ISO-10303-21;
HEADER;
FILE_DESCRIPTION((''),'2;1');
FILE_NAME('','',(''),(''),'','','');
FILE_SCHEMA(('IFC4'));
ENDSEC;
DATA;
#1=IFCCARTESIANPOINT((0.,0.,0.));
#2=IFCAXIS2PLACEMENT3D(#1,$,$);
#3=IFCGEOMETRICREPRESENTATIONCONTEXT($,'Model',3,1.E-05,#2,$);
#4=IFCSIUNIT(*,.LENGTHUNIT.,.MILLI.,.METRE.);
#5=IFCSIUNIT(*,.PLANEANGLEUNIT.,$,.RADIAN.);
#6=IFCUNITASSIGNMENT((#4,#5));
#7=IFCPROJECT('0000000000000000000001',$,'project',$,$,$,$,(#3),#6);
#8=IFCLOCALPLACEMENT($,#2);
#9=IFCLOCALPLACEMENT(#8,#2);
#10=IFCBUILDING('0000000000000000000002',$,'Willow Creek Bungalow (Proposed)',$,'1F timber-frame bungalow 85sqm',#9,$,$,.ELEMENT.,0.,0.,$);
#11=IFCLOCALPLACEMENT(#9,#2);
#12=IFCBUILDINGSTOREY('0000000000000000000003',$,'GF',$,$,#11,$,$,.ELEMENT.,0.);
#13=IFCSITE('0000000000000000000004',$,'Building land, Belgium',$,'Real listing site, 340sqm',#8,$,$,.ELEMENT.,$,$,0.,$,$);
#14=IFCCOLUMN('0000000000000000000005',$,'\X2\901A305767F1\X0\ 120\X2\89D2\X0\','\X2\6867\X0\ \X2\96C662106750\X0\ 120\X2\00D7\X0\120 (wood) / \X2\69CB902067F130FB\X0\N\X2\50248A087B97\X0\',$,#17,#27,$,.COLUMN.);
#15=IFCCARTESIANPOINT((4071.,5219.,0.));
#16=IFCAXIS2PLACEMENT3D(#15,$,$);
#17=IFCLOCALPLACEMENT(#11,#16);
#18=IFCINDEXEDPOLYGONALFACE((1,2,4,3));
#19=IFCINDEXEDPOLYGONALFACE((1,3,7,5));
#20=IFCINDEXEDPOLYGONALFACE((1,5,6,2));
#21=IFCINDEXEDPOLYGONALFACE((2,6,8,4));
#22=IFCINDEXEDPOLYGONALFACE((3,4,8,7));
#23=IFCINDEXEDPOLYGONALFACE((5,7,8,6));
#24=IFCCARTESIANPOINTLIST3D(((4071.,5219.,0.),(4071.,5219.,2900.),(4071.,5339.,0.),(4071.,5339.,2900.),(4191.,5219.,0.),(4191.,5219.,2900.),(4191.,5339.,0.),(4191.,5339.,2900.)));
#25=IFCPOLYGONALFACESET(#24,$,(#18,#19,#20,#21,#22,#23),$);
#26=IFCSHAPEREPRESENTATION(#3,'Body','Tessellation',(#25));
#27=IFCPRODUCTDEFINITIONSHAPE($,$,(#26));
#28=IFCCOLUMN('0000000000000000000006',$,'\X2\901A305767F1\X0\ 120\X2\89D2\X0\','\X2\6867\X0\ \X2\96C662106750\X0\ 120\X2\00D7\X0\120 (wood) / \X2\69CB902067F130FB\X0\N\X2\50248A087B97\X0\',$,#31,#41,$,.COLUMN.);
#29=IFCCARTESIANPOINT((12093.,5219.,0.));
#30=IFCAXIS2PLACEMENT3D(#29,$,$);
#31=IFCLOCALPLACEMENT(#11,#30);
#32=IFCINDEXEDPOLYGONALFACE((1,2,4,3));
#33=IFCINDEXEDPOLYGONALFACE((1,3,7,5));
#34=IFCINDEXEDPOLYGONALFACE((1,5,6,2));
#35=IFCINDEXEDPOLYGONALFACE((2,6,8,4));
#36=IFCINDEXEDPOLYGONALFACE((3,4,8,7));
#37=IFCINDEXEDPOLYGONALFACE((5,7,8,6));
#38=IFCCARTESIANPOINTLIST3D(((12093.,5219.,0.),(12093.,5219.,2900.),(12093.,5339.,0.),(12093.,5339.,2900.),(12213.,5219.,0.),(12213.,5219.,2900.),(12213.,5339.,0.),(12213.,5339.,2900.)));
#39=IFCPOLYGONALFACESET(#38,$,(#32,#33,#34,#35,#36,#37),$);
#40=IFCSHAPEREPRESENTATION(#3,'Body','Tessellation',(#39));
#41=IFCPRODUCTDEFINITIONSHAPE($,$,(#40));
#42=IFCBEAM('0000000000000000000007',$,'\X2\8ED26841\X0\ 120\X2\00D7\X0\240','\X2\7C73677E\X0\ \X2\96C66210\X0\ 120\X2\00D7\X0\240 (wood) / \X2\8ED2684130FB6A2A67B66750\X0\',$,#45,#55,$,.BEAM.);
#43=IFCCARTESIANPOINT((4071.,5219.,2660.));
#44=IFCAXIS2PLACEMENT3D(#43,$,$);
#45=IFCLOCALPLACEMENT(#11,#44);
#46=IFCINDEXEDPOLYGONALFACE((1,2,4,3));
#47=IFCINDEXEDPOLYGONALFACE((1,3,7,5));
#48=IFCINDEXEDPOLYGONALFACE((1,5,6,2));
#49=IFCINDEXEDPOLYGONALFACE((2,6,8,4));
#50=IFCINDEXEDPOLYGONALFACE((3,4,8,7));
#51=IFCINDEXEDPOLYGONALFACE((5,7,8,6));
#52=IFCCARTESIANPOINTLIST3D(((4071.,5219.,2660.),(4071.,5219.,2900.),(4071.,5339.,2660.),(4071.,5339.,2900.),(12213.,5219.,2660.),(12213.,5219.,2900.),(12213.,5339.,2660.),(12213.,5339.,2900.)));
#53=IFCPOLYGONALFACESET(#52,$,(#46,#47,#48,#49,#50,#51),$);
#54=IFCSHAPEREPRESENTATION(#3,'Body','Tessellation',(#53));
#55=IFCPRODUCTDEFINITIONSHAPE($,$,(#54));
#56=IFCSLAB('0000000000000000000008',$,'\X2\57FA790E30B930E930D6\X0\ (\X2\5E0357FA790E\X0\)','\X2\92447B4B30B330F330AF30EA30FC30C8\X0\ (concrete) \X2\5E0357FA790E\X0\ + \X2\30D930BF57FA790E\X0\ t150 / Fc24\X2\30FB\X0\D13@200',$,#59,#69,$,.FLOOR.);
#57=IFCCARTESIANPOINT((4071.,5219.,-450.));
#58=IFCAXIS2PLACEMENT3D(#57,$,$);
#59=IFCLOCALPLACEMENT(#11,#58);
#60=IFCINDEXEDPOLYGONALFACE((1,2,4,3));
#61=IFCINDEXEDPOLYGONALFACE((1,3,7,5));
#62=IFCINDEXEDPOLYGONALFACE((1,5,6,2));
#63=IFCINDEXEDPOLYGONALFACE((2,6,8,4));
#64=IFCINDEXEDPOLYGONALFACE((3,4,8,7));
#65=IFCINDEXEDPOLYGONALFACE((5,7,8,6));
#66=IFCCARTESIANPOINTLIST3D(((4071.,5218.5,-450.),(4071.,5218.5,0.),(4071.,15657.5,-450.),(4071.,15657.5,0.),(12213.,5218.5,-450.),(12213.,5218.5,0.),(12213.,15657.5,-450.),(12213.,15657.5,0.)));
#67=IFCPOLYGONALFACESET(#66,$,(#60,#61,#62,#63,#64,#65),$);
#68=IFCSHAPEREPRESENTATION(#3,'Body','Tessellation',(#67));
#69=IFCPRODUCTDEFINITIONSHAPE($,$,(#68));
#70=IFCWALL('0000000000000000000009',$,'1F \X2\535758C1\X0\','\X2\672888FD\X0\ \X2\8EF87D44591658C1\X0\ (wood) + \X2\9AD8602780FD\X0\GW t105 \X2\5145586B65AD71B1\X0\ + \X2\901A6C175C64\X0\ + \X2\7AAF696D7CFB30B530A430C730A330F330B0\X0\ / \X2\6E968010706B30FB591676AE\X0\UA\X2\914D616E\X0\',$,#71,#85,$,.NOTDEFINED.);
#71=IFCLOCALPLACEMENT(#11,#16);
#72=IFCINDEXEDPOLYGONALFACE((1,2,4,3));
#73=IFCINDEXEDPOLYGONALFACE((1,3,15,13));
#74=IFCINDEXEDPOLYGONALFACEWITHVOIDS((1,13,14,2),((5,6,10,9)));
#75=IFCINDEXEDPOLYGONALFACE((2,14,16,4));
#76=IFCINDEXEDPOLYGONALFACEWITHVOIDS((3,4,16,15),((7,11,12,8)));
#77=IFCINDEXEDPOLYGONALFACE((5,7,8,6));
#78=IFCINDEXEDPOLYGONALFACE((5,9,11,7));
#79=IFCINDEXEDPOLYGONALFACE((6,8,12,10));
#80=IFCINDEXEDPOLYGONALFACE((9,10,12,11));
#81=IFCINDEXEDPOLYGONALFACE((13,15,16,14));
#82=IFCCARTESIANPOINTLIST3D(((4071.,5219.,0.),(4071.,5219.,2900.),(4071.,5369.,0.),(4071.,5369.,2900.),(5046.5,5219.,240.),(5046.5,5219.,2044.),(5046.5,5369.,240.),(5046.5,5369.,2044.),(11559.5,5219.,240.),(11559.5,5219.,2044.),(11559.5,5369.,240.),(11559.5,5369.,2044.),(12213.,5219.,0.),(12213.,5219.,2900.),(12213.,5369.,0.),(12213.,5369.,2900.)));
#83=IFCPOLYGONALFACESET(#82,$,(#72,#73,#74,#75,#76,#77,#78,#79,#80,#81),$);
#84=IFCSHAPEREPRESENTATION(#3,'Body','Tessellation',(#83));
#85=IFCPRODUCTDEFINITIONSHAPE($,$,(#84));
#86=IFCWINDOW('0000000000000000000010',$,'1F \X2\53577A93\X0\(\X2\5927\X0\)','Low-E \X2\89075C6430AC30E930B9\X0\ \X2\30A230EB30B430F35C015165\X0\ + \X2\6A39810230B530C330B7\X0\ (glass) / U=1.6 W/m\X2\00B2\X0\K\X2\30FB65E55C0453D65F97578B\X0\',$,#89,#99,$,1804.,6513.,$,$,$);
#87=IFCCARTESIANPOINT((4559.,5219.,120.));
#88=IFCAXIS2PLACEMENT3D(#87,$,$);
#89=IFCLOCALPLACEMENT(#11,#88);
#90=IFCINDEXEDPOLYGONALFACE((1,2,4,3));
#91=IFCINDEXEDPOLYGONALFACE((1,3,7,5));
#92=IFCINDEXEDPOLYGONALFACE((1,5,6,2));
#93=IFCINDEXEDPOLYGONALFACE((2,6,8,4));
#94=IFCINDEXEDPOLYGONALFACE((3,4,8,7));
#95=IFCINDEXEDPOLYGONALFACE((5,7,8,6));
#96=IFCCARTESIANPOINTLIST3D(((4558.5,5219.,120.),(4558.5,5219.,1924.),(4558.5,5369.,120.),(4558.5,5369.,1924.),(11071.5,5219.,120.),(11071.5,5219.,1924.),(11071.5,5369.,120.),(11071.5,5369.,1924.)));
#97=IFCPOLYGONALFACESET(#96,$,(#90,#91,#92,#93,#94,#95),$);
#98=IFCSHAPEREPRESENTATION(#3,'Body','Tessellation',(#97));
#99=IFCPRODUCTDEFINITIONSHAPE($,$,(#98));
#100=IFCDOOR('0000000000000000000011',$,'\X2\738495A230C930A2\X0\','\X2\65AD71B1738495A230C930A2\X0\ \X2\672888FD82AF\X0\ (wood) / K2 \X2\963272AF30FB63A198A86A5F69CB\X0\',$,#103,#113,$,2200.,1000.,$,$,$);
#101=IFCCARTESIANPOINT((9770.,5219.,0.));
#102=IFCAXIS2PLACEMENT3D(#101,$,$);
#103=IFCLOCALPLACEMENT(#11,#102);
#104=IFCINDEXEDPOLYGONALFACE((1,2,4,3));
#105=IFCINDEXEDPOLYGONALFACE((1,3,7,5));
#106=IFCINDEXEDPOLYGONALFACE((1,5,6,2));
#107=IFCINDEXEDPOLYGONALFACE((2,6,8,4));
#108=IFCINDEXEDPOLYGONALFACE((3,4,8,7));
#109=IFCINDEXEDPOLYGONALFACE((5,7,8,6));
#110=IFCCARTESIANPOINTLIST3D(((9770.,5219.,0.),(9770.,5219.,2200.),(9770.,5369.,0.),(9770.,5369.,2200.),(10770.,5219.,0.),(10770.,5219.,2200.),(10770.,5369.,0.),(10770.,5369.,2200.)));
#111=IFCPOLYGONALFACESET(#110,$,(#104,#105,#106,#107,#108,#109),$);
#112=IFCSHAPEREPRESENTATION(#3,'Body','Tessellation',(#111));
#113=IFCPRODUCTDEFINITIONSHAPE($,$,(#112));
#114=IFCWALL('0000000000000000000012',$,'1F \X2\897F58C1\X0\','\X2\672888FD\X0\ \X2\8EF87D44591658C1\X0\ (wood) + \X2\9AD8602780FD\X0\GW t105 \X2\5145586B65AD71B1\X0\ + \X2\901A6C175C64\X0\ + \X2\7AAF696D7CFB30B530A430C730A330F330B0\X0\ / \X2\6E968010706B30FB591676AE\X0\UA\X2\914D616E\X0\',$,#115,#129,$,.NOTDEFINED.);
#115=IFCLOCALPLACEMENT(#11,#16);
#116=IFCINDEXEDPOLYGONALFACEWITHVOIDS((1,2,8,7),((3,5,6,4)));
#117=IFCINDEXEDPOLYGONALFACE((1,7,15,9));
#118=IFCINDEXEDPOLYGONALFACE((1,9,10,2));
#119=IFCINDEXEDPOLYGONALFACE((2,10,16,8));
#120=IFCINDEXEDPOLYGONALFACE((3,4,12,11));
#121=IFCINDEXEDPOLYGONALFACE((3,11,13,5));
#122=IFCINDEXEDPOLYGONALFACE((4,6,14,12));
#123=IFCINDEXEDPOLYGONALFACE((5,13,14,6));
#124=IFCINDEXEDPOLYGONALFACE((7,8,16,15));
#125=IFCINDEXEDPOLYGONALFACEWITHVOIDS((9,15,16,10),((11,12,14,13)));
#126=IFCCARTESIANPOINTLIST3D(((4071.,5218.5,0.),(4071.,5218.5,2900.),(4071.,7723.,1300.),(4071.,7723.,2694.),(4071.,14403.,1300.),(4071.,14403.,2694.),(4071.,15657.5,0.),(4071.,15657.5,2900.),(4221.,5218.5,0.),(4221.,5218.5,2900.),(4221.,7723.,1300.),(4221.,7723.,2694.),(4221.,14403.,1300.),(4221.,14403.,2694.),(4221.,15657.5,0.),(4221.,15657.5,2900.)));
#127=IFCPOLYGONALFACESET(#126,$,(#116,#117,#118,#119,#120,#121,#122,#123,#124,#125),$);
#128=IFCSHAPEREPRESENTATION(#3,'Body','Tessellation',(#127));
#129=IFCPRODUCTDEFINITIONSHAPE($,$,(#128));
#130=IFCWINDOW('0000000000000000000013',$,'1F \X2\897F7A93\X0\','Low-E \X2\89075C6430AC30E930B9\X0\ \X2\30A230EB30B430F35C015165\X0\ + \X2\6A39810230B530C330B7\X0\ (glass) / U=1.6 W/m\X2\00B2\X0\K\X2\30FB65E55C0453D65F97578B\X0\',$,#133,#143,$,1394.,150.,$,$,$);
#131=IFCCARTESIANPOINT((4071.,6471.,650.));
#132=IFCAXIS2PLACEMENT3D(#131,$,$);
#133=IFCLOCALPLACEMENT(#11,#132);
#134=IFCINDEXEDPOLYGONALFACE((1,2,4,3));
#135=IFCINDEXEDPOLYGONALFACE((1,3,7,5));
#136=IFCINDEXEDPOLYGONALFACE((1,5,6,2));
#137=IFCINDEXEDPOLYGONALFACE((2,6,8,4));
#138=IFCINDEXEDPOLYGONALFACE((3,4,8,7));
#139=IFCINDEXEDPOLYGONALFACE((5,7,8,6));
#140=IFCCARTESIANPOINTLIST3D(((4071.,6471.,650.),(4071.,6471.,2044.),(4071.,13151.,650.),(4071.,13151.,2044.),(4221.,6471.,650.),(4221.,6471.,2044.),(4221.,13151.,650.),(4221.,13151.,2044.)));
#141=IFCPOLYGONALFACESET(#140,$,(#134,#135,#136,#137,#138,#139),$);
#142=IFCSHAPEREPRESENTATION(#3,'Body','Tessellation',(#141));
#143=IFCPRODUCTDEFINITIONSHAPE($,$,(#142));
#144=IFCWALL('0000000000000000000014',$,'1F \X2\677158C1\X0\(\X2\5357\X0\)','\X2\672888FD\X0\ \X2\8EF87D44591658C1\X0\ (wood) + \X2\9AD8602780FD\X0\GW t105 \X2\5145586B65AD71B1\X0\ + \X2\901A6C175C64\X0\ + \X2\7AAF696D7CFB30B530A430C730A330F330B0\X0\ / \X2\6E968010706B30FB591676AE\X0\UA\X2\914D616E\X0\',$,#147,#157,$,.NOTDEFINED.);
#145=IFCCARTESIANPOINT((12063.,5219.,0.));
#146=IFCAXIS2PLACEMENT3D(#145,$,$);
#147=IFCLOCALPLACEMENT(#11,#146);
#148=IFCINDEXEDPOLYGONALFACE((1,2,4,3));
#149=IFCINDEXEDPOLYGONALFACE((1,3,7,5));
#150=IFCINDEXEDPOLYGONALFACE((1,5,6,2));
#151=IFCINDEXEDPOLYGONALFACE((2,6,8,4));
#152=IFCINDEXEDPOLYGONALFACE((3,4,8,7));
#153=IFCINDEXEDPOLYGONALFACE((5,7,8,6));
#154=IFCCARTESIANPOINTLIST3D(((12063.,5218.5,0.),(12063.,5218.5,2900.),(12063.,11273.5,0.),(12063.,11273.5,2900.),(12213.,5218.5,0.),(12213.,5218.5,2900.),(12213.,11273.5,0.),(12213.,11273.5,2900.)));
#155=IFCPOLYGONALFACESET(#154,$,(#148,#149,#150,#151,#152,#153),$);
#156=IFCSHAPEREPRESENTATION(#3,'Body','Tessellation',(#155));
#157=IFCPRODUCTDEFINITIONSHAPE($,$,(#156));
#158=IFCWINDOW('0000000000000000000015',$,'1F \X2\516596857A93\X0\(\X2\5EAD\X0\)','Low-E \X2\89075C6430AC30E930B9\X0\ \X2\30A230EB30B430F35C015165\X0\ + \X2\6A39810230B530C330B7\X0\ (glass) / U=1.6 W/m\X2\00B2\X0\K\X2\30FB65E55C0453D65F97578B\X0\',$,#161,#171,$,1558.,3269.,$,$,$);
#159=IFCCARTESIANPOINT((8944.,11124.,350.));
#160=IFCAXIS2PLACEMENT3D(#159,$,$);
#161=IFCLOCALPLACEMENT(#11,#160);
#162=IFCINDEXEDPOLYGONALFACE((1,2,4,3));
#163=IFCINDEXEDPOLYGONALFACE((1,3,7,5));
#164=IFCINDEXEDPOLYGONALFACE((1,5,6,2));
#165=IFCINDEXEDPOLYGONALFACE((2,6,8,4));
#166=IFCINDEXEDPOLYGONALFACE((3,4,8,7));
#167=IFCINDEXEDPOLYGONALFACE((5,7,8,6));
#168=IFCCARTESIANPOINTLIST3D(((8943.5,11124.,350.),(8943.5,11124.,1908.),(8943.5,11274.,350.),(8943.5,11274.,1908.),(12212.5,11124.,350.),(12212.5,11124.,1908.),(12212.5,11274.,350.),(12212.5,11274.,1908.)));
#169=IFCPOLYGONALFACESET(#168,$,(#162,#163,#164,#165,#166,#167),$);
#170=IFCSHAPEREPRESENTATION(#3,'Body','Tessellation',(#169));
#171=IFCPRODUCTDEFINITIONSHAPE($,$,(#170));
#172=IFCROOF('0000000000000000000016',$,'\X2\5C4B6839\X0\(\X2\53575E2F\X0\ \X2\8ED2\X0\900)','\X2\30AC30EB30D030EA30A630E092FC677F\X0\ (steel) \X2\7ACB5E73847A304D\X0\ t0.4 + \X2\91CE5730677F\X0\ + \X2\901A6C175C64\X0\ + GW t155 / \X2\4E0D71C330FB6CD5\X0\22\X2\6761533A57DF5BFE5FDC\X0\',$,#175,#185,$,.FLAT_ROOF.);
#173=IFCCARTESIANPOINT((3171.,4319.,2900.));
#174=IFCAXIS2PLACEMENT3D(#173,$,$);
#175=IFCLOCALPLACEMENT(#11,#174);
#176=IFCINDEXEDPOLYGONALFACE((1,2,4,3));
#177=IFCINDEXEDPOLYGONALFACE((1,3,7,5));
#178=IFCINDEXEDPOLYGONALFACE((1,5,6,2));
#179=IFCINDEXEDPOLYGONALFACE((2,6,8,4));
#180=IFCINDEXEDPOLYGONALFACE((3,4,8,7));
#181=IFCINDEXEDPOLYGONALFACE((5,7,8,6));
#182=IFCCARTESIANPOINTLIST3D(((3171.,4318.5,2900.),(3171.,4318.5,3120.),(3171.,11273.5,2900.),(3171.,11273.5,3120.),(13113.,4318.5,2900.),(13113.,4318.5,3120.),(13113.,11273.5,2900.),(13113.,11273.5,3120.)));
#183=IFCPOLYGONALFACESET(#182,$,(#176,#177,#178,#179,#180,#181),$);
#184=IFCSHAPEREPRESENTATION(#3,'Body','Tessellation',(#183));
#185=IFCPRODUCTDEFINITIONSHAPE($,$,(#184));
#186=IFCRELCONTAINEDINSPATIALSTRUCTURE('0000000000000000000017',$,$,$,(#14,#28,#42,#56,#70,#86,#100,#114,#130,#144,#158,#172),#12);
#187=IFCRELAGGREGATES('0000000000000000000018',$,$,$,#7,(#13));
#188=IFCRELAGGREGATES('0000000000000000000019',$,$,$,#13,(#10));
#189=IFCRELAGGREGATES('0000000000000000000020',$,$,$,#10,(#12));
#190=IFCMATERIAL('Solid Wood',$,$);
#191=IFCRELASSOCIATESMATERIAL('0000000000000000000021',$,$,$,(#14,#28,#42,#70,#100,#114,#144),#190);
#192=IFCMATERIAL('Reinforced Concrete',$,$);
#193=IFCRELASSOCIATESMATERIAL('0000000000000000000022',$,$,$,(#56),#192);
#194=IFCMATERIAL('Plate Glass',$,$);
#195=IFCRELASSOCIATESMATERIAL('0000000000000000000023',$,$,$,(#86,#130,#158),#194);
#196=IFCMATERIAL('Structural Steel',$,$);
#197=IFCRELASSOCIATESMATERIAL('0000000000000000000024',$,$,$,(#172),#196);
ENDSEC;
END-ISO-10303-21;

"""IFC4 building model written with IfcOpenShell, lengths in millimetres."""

from ifc_helpers import new_model, si_unit, frame, frame_2d, origin, place, context, project, spatial, rectangle, extrude, material, element, fill, save


model = new_model("IFC4")

# Units and contexts
model_context = context("Model", 3, precision=1e-05, world=origin())
ifc_project = project(units=[si_unit("LENGTHUNIT", "METRE", prefix="MILLI"), si_unit("PLANEANGLEUNIT", "RADIAN")], contexts=[model_context])

# Site, building, storey
site_placement = place(None, origin())
site = spatial("IfcSite", under=ifc_project, at=site_placement, Name="Building land, Belgium", ObjectType="Real listing site, 340sqm", CompositionType="ELEMENT", RefElevation=0.0)
building_placement = place(site_placement, origin())
building = spatial("IfcBuilding", under=site, at=building_placement, Name="Willow Creek Bungalow (Proposed)", ObjectType="1F timber-frame bungalow 85sqm", CompositionType="ELEMENT", ElevationOfRefHeight=0.0, ElevationOfTerrain=0.0)
storey_placement = place(building_placement, origin())
storey = spatial("IfcBuildingStorey", under=building, at=storey_placement, Name="GF", CompositionType="ELEMENT", Elevation=0.0)

# Columns
ifc_material_1 = material(Name="Solid Wood")
column_1_placement = place(storey_placement, frame((4071.0, 5219.0, 0.0)))
element("IfcColumn", 1, at=column_1_placement, inside=storey, material=ifc_material_1, Name="通し柱 120角", Description="桧 集成材 120×120 (wood) / 構造柱・N値計算", PredefinedType="COLUMN", context=model_context, shape_type="SweptSolid", body=[
    extrude(rectangle(XDim=120.0, YDim=120.0, at=frame_2d((60.0, 60.0))), frame((4071.0, 5219.0, 0.0)), (0.0, 0.0, 1.0), 2900.0),
])
column_2_placement = place(storey_placement, frame((12093.0, 5219.0, 0.0)))
element("IfcColumn", 2, at=column_2_placement, inside=storey, material=ifc_material_1, Name="通し柱 120角", Description="桧 集成材 120×120 (wood) / 構造柱・N値計算", PredefinedType="COLUMN", context=model_context, shape_type="SweptSolid", body=[
    extrude(rectangle(XDim=120.0, YDim=120.0, at=frame_2d((60.0, 60.0))), frame((12093.0, 5219.0, 0.0)), (0.0, 0.0, 1.0), 2900.0),
])

# Beam
beam_1_placement = place(storey_placement, frame((4071.0, 5219.0, 2660.0)))
element("IfcBeam", 3, at=beam_1_placement, inside=storey, material=ifc_material_1, Name="軒桁 120×240", Description="米松 集成 120×240 (wood) / 軒桁・横架材", PredefinedType="BEAM", context=model_context, shape_type="SweptSolid", body=[
    extrude(rectangle(XDim=8142.0, YDim=120.0, at=frame_2d((4071.0, 60.0))), frame((4071.0, 5219.0, 2660.0)), (0.0, 0.0, 1.0), 240.0),
])

# Slab
ifc_material_2 = material(Name="Reinforced Concrete")
slab_1_placement = place(storey_placement, frame((4071.0, 5219.0, -450.0)))
element("IfcSlab", 4, at=slab_1_placement, inside=storey, material=ifc_material_2, Name="基礎スラブ (布基礎)", Description="鉄筋コンクリート (concrete) 布基礎 + ベタ基礎 t150 / Fc24・D13@200", PredefinedType="FLOOR", context=model_context, shape_type="SweptSolid", body=[
    extrude(rectangle(XDim=8142.0, YDim=10439.0, at=frame_2d((4071.0, 5219.0))), frame((4071.0, 5219.0, -450.0)), (0.0, 0.0, 1.0), 450.0),
])

# Wall, openings, window, door
wall_1_placement = place(storey_placement, frame((4071.0, 5219.0, 0.0)))
wall_1 = element("IfcWall", 5, at=wall_1_placement, inside=storey, material=ifc_material_1, Name="1F 南壁", Description="木製 軸組外壁 (wood) + 高性能GW t105 充填断熱 + 通気層 + 窯業系サイディング / 準耐火・外皮UA配慮", PredefinedType="NOTDEFINED", context=model_context, shape_type="SweptSolid", body=[
    extrude(rectangle(XDim=8142.0, YDim=150.0, at=frame_2d((4071.0, 75.0))), frame((4071.0, 5219.0, 0.0)), (0.0, 0.0, 1.0), 2900.0),
])
opening_1_placement = place(storey_placement, frame((4559.0, 5219.0, 120.0)))
opening_1 = element("IfcOpeningElement", 6, at=opening_1_placement, cuts=wall_1, PredefinedType="NOTDEFINED", context=model_context, shape_type="SweptSolid", body=[
    extrude(rectangle(XDim=6513.0, YDim=150.0, at=frame_2d((3256.0, 75.0))), frame((4559.0, 5219.0, 120.0)), (0.0, 0.0, 1.0), 1804.0),
])
opening_2_placement = place(storey_placement, frame((9770.0, 5219.0, 0.0)))
opening_2 = element("IfcOpeningElement", 7, at=opening_2_placement, cuts=wall_1, PredefinedType="NOTDEFINED", context=model_context, shape_type="SweptSolid", body=[
    extrude(rectangle(XDim=1000.0, YDim=150.0, at=frame_2d((500.0, 75.0))), frame((9770.0, 5219.0, 0.0)), (0.0, 0.0, 1.0), 2200.0),
])
ifc_material_3 = material(Name="Plate Glass")
window_1_placement = place(storey_placement, frame((4559.0, 5219.0, 120.0)))
window_1 = element("IfcWindow", 8, at=window_1_placement, inside=storey, material=ifc_material_3, Name="1F 南窓(大)", Description="Low-E 複層ガラス アルゴン封入 + 樹脂サッシ (glass) / U=1.6 W/m²K・日射取得型", OverallHeight=1804.0, OverallWidth=6513.0, context=model_context, shape_type="SweptSolid", body=[
    extrude(rectangle(XDim=6513.0, YDim=150.0, at=frame_2d((3256.0, 75.0))), frame((4559.0, 5219.0, 120.0)), (0.0, 0.0, 1.0), 1804.0),
])
fill(opening_1, window_1)
door_1_placement = place(storey_placement, frame((9770.0, 5219.0, 0.0)))
door_1 = element("IfcDoor", 9, at=door_1_placement, inside=storey, material=ifc_material_1, Name="玄関ドア", Description="断熱玄関ドア 木製芯 (wood) / K2 防犯・採風機構", OverallHeight=2200.0, OverallWidth=1000.0, context=model_context, shape_type="SweptSolid", body=[
    extrude(rectangle(XDim=1000.0, YDim=150.0, at=frame_2d((500.0, 75.0))), frame((9770.0, 5219.0, 0.0)), (0.0, 0.0, 1.0), 2200.0),
])
fill(opening_2, door_1)

# Walls, openings, windows
wall_2_placement = place(storey_placement, frame((4071.0, 5219.0, 0.0)))
wall_2 = element("IfcWall", 10, at=wall_2_placement, inside=storey, material=ifc_material_1, Name="1F 西壁", Description="木製 軸組外壁 (wood) + 高性能GW t105 充填断熱 + 通気層 + 窯業系サイディング / 準耐火・外皮UA配慮", PredefinedType="NOTDEFINED", context=model_context, shape_type="SweptSolid", body=[
    extrude(rectangle(XDim=150.0, YDim=10439.0, at=frame_2d((75.0, 5219.0))), frame((4071.0, 5219.0, 0.0)), (0.0, 0.0, 1.0), 2900.0),
])
opening_3_placement = place(storey_placement, frame((4071.0, 6471.0, 650.0)))
opening_3 = element("IfcOpeningElement", 11, at=opening_3_placement, cuts=wall_2, PredefinedType="NOTDEFINED", context=model_context, shape_type="SweptSolid", body=[
    extrude(rectangle(XDim=150.0, YDim=6680.0, at=frame_2d((75.0, 3340.0))), frame((4071.0, 6471.0, 650.0)), (0.0, 0.0, 1.0), 1394.0),
])
window_2_placement = place(storey_placement, frame((4071.0, 6471.0, 650.0)))
window_2 = element("IfcWindow", 12, at=window_2_placement, inside=storey, material=ifc_material_3, Name="1F 西窓", Description="Low-E 複層ガラス アルゴン封入 + 樹脂サッシ (glass) / U=1.6 W/m²K・日射取得型", OverallHeight=1394.0, OverallWidth=150.0, context=model_context, shape_type="SweptSolid", body=[
    extrude(rectangle(XDim=150.0, YDim=6680.0, at=frame_2d((75.0, 3340.0))), frame((4071.0, 6471.0, 650.0)), (0.0, 0.0, 1.0), 1394.0),
])
fill(opening_3, window_2)
wall_3_placement = place(storey_placement, frame((12063.0, 5219.0, 0.0)))
wall_3 = element("IfcWall", 13, at=wall_3_placement, inside=storey, material=ifc_material_1, Name="1F 東壁(南)", Description="木製 軸組外壁 (wood) + 高性能GW t105 充填断熱 + 通気層 + 窯業系サイディング / 準耐火・外皮UA配慮", PredefinedType="NOTDEFINED", context=model_context, shape_type="SweptSolid", body=[
    extrude(rectangle(XDim=150.0, YDim=6055.0, at=frame_2d((75.0, 3027.0))), frame((12063.0, 5219.0, 0.0)), (0.0, 0.0, 1.0), 2900.0),
])
opening_4_placement = place(storey_placement, frame((8944.0, 11124.0, 350.0)))
opening_4 = element("IfcOpeningElement", 14, at=opening_4_placement, cuts=wall_3, PredefinedType="NOTDEFINED", context=model_context, shape_type="SweptSolid", body=[
    extrude(rectangle(XDim=3269.0, YDim=150.0, at=frame_2d((1634.0, 75.0))), frame((8944.0, 11124.0, 350.0)), (0.0, 0.0, 1.0), 1558.0),
])
window_3_placement = place(storey_placement, frame((8944.0, 11124.0, 350.0)))
window_3 = element("IfcWindow", 15, at=window_3_placement, inside=storey, material=ifc_material_3, Name="1F 入隅窓(庭)", Description="Low-E 複層ガラス アルゴン封入 + 樹脂サッシ (glass) / U=1.6 W/m²K・日射取得型", OverallHeight=1558.0, OverallWidth=3269.0, context=model_context, shape_type="SweptSolid", body=[
    extrude(rectangle(XDim=3269.0, YDim=150.0, at=frame_2d((1634.0, 75.0))), frame((8944.0, 11124.0, 350.0)), (0.0, 0.0, 1.0), 1558.0),
])
fill(opening_4, window_3)

# Roof
ifc_material_4 = material(Name="Structural Steel")
roof_placement = place(storey_placement, frame((3171.0, 4319.0, 2900.0)))
element("IfcRoof", 16, at=roof_placement, inside=storey, material=ifc_material_4, Name="屋根(南帯 軒900)", Description="ガルバリウム鋼板 (steel) 立平葺き t0.4 + 野地板 + 通気層 + GW t155 / 不燃・法22条区域対応", PredefinedType="FLAT_ROOF", context=model_context, shape_type="SweptSolid", body=[
    extrude(rectangle(XDim=9942.0, YDim=6955.0, at=frame_2d((4971.0, 3477.0))), frame((3171.0, 4319.0, 2900.0)), (0.0, 0.0, 1.0), 220.0),
])

save(model, "model.ifc")
